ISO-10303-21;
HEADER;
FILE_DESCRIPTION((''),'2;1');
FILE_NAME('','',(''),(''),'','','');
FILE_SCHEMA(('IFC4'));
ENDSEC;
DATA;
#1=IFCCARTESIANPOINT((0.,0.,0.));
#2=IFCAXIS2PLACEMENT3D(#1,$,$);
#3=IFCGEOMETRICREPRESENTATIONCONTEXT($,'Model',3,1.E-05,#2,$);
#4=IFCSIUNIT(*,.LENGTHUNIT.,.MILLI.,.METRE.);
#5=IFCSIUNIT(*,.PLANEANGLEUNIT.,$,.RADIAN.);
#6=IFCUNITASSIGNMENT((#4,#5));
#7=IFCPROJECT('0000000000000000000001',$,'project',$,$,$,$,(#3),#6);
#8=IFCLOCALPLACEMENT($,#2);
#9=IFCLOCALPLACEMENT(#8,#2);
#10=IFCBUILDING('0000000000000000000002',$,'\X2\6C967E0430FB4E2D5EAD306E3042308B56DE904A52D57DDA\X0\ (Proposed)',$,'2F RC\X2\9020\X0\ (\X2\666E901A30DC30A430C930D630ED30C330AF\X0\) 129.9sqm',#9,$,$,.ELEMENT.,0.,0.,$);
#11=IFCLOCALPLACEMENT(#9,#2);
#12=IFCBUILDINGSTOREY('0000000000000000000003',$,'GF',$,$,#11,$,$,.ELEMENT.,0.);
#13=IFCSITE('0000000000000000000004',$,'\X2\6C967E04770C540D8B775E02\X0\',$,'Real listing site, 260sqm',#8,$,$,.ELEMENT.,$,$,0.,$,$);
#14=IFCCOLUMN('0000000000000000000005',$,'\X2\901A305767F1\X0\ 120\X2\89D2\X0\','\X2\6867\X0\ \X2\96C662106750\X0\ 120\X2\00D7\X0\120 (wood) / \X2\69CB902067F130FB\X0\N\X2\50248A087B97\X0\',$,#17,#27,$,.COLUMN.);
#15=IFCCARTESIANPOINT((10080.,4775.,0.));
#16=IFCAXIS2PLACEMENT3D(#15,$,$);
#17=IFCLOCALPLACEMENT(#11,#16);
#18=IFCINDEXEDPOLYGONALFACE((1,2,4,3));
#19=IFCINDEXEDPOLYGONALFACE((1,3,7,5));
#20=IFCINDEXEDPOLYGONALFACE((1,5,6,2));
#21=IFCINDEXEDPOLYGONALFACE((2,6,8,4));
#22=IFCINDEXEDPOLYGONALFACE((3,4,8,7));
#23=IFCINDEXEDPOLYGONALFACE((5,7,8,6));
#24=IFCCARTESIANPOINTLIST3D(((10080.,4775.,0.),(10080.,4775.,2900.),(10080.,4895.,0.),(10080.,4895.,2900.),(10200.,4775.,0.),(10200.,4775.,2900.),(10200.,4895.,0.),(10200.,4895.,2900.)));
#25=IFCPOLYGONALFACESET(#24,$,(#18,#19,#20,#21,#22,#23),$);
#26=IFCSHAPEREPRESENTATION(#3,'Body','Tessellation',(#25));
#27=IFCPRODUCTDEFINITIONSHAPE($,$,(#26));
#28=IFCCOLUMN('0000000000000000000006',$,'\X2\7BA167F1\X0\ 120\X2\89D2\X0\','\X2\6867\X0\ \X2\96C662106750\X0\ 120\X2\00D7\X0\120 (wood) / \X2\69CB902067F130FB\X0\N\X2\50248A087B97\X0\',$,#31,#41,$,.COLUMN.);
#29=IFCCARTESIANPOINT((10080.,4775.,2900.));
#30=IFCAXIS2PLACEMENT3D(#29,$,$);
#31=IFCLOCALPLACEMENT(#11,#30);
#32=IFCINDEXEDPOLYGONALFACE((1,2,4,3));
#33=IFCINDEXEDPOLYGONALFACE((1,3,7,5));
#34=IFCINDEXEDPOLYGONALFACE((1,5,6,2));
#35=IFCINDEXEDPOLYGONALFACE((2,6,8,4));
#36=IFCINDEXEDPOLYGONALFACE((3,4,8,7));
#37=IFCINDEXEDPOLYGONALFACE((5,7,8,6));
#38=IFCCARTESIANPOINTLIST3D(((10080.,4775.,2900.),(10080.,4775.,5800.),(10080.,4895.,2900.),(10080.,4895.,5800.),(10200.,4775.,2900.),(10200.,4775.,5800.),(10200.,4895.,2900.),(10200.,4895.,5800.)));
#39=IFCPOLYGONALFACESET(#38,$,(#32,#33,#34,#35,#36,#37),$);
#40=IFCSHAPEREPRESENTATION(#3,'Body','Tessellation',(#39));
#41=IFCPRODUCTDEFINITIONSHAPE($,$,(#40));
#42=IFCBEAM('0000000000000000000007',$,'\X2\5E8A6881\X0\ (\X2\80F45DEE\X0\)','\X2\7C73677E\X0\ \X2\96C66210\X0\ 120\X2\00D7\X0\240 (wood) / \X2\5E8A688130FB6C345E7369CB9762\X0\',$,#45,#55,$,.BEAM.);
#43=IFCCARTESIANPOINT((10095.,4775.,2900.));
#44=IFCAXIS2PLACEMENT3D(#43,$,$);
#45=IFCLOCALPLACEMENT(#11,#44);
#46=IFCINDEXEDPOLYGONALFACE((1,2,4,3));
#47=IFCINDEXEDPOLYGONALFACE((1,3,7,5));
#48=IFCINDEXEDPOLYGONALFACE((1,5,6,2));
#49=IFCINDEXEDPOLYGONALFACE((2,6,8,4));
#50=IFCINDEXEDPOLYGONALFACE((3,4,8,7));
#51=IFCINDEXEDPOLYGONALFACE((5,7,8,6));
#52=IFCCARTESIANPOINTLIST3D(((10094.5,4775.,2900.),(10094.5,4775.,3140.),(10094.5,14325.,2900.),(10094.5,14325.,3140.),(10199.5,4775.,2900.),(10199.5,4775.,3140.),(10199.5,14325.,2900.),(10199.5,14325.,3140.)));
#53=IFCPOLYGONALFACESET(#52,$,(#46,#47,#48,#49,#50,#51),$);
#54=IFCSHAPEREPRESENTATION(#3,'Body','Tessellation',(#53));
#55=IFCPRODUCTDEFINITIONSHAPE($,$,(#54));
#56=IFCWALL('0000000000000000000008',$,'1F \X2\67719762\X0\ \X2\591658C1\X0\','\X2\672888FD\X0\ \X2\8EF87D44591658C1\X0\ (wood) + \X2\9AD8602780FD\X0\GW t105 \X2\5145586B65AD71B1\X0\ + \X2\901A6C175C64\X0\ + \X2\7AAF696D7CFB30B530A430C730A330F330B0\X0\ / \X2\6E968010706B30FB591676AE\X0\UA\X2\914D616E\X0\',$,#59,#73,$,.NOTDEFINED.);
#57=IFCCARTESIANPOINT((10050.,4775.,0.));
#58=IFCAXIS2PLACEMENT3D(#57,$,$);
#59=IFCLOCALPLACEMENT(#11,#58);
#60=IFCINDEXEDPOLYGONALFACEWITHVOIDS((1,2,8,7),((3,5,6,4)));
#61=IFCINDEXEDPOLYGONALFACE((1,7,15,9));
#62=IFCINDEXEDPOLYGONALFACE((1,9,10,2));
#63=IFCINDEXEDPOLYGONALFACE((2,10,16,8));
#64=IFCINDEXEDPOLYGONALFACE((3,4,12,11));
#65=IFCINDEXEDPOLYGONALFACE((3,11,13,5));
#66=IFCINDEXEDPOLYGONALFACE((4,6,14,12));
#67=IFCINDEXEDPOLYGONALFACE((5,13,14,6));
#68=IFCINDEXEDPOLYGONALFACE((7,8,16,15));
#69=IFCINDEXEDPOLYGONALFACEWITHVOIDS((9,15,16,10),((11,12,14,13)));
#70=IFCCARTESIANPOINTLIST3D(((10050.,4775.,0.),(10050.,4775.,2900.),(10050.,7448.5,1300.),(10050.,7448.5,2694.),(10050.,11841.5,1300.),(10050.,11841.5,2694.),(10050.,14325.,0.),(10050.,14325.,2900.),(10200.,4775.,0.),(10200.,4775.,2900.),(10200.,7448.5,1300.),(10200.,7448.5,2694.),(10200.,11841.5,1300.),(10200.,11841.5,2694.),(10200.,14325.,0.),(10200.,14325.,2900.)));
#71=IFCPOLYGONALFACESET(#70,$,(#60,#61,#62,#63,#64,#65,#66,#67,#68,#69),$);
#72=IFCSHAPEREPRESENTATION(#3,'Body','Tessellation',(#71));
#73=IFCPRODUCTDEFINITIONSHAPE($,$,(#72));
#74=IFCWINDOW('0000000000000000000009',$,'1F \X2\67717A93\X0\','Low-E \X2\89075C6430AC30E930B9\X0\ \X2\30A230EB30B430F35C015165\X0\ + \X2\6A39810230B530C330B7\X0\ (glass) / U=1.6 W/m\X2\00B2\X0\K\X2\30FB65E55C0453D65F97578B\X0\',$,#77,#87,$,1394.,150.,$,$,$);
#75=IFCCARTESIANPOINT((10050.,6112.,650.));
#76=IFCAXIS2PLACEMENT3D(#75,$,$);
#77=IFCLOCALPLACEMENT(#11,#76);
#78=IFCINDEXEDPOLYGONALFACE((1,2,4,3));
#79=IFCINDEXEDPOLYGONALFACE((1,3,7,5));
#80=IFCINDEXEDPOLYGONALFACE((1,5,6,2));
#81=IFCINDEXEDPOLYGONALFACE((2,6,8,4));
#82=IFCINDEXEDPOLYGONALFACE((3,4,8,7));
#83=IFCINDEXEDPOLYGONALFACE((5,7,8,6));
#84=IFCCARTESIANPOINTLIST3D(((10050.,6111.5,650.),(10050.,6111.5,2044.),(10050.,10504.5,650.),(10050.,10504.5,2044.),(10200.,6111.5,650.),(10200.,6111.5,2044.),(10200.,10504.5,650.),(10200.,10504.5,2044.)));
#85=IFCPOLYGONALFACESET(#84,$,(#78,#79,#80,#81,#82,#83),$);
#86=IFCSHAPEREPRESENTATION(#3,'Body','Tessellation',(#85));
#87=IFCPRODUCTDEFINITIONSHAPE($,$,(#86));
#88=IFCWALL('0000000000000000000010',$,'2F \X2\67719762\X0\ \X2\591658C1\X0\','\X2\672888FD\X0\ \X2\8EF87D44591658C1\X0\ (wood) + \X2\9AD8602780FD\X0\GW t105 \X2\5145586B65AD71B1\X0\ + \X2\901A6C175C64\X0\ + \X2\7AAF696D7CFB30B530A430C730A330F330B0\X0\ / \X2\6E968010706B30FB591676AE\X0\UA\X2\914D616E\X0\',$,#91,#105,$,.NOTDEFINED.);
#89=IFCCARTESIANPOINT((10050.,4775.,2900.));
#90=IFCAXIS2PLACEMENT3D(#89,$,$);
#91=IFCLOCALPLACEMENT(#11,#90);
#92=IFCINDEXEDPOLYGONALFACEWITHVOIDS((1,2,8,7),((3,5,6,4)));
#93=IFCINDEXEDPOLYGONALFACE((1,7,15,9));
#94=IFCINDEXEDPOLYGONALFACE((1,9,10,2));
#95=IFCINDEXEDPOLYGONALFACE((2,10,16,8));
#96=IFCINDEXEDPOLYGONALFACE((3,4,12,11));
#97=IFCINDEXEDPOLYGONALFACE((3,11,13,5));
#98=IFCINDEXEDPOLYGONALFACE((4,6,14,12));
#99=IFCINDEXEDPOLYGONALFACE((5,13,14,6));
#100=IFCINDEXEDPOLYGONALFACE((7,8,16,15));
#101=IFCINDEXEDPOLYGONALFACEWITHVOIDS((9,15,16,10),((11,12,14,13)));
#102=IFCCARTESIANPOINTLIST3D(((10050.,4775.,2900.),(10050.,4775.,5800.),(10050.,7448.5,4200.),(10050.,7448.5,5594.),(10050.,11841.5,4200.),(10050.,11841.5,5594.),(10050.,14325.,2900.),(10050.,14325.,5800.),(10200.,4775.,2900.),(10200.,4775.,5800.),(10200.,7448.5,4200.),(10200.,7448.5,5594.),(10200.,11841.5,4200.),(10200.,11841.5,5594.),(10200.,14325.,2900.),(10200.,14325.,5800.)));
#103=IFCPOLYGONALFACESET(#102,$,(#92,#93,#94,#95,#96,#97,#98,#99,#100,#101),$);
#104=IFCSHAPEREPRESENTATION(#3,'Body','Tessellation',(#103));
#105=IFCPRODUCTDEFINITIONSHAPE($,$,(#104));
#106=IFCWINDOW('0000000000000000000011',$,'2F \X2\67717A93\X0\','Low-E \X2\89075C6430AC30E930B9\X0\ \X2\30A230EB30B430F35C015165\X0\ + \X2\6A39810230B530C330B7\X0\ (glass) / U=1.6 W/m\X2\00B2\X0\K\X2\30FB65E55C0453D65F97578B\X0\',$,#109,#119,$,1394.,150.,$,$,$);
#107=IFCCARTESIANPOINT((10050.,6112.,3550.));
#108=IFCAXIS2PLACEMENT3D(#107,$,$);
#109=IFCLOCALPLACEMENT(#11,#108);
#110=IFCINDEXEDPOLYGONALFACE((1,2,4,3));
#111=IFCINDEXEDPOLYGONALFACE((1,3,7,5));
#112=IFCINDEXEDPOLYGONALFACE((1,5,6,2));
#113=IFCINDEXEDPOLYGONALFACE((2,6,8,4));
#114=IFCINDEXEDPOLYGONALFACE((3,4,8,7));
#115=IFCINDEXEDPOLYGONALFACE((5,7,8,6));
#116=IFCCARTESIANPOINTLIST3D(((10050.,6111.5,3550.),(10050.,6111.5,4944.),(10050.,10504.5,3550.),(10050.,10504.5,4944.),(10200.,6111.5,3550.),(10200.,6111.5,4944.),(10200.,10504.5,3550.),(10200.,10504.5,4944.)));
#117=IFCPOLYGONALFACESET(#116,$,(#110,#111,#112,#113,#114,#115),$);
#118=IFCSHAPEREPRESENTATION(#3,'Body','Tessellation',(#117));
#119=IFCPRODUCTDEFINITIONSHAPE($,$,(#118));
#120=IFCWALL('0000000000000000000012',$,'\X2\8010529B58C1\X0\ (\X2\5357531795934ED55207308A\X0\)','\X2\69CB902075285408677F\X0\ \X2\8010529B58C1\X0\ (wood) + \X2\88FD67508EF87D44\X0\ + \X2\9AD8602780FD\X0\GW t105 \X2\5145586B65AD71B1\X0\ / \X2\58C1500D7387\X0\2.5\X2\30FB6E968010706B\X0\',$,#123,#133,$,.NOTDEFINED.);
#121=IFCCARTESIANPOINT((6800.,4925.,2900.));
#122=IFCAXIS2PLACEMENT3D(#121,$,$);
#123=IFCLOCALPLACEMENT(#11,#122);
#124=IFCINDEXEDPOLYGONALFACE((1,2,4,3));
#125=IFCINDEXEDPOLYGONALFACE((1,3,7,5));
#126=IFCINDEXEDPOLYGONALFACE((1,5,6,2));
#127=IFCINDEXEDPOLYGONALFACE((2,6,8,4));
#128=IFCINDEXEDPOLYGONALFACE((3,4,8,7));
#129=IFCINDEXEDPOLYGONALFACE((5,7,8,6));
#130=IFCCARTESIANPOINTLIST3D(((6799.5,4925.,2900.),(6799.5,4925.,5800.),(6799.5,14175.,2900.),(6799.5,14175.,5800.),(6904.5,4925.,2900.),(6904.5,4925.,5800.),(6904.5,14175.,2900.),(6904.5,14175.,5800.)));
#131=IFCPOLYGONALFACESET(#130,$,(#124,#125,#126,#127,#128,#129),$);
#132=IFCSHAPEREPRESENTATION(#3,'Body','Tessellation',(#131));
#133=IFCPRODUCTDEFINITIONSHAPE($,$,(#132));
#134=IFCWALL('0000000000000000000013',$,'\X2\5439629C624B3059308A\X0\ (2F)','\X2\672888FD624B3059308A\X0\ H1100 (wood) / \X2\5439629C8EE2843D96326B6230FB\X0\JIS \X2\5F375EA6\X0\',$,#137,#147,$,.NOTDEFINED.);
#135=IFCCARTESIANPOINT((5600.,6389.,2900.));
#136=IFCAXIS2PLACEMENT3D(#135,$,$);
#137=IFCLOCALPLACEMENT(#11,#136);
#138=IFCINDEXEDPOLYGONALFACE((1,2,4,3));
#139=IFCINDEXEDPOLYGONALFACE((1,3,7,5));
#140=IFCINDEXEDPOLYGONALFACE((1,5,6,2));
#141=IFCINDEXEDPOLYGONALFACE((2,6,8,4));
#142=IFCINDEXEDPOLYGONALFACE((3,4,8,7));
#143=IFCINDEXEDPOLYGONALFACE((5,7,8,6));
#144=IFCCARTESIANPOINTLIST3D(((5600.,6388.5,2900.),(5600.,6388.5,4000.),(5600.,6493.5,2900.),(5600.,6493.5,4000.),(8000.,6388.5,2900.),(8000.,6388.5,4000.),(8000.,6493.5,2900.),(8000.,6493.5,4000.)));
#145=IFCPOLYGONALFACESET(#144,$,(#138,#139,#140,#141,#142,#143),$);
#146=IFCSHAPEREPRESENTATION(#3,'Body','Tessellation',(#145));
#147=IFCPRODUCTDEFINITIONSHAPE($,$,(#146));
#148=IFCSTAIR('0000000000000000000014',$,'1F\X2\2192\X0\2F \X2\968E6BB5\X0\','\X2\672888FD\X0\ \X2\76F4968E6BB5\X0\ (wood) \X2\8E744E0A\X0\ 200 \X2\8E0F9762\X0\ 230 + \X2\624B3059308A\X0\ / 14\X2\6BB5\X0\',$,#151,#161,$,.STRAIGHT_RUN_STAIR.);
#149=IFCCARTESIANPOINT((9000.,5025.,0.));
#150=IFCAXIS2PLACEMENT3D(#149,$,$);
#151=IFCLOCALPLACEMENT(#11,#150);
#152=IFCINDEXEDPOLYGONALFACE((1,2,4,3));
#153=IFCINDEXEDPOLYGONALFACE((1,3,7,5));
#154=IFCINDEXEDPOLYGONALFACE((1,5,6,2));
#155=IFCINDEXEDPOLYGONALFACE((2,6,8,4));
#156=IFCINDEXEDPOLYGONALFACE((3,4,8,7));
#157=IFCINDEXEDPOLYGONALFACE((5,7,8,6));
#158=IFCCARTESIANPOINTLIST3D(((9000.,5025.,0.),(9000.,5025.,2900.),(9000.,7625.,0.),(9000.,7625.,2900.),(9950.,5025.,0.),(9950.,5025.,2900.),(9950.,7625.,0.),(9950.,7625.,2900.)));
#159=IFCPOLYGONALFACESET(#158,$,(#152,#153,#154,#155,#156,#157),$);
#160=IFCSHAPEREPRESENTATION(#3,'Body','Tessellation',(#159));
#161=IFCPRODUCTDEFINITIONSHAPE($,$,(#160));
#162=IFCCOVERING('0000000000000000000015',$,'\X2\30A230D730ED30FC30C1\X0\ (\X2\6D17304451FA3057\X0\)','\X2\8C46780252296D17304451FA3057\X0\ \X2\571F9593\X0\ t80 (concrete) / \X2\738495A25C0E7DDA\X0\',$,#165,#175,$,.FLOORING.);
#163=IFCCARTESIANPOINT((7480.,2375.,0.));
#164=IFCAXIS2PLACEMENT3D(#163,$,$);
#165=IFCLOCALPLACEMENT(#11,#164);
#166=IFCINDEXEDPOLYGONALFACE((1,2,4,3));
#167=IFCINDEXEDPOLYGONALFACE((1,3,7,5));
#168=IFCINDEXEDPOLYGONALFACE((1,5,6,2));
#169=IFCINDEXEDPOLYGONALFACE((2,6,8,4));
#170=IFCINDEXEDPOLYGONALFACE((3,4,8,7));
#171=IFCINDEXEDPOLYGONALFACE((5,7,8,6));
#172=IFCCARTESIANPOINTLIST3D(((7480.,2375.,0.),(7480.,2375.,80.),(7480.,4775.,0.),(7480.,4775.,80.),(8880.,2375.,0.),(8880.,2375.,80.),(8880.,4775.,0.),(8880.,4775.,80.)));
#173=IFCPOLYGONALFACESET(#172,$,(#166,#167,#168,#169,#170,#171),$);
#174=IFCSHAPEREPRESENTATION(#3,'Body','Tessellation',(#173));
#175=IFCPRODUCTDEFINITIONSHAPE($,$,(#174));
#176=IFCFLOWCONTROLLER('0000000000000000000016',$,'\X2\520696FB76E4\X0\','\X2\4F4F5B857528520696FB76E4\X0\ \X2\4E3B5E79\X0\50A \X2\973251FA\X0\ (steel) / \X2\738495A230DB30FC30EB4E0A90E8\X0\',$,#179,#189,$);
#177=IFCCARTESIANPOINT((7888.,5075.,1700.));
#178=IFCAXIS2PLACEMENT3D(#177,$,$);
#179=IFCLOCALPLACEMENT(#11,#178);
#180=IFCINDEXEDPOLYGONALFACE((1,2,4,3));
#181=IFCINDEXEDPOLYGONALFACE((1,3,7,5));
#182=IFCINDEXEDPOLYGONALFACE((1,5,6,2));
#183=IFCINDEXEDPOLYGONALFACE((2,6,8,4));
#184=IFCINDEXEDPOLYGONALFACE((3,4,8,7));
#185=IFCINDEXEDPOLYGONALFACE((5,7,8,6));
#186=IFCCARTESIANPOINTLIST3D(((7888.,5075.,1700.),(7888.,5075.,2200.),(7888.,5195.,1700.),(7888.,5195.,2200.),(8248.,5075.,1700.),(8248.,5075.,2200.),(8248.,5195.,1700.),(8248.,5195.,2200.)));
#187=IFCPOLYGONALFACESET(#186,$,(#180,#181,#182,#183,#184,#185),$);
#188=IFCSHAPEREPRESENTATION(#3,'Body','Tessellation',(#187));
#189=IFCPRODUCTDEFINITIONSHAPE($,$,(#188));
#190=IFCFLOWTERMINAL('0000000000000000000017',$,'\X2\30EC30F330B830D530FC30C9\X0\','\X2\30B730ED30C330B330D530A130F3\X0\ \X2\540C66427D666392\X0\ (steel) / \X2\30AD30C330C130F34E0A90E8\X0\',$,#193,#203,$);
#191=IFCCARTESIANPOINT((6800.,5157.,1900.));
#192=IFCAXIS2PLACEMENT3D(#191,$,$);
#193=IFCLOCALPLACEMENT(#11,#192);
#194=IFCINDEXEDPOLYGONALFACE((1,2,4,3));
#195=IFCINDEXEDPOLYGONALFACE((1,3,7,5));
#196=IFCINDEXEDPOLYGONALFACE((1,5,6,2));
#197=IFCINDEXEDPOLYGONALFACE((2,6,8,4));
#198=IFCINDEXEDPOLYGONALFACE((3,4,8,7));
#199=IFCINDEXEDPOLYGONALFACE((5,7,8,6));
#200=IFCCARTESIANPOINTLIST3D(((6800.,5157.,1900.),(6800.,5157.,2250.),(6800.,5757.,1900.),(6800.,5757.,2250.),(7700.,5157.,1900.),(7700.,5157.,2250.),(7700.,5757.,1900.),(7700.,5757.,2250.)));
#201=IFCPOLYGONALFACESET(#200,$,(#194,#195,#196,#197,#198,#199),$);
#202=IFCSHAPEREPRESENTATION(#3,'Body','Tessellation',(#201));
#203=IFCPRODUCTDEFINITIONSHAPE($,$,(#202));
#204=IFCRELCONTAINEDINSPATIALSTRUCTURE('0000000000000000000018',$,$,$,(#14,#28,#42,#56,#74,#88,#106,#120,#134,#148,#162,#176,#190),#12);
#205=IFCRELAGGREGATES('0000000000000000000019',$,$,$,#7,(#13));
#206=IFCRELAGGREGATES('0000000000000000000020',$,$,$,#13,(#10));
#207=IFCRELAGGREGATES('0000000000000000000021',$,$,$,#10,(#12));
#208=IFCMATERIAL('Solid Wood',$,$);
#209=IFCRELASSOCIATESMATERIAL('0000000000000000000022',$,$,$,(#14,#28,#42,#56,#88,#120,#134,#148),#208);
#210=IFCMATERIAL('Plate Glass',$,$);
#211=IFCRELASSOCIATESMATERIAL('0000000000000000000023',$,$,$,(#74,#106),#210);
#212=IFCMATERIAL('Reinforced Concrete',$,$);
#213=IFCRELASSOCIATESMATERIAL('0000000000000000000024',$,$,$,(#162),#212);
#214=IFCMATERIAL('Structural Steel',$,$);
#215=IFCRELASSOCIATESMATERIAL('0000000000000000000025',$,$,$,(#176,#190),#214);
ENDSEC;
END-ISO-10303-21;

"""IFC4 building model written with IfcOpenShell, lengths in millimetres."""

from ifc_helpers import new_model, si_unit, frame, frame_2d, origin, place, context, project, spatial, rectangle, extrude, material, element, fill, save


model = new_model("IFC4")

# Units and contexts
model_context = context("Model", 3, precision=1e-05, world=origin())
ifc_project = project(units=[si_unit("LENGTHUNIT", "METRE", prefix="MILLI"), si_unit("PLANEANGLEUNIT", "RADIAN")], contexts=[model_context])

# Site, building, storey
site_placement = place(None, origin())
site = spatial("IfcSite", under=ifc_project, at=site_placement, Name="沖縄県名護市", ObjectType="Real listing site, 260sqm", CompositionType="ELEMENT", RefElevation=0.0)
building_placement = place(site_placement, origin())
building = spatial("IfcBuilding", under=site, at=building_placement, Name="沖縄・中庭のある回遊動線 (Proposed)", ObjectType="2F RC造 (普通ボイドブロック) 129.9sqm", CompositionType="ELEMENT", ElevationOfRefHeight=0.0, ElevationOfTerrain=0.0)
storey_placement = place(building_placement, origin())
storey = spatial("IfcBuildingStorey", under=building, at=storey_placement, Name="GF", CompositionType="ELEMENT", Elevation=0.0)

# Columns
ifc_material_1 = material(Name="Solid Wood")
column_1_placement = place(storey_placement, frame((10080.0, 4775.0, 0.0)))
element("IfcColumn", 1, at=column_1_placement, inside=storey, material=ifc_material_1, Name="通し柱 120角", Description="桧 集成材 120×120 (wood) / 構造柱・N値計算", PredefinedType="COLUMN", context=model_context, shape_type="SweptSolid", body=[
    extrude(rectangle(XDim=120.0, YDim=120.0, at=frame_2d((60.0, 60.0))), frame((10080.0, 4775.0, 0.0)), (0.0, 0.0, 1.0), 2900.0),
])
column_2_placement = place(storey_placement, frame((10080.0, 4775.0, 2900.0)))
element("IfcColumn", 2, at=column_2_placement, inside=storey, material=ifc_material_1, Name="管柱 120角", Description="桧 集成材 120×120 (wood) / 構造柱・N値計算", PredefinedType="COLUMN", context=model_context, shape_type="SweptSolid", body=[
    extrude(rectangle(XDim=120.0, YDim=120.0, at=frame_2d((60.0, 60.0))), frame((10080.0, 4775.0, 2900.0)), (0.0, 0.0, 1.0), 2900.0),
])

# Beam
beam_1_placement = place(storey_placement, frame((10095.0, 4775.0, 2900.0)))
element("IfcBeam", 3, at=beam_1_placement, inside=storey, material=ifc_material_1, Name="床梁 (胴差)", Description="米松 集成 120×240 (wood) / 床梁・水平構面", PredefinedType="BEAM", context=model_context, shape_type="SweptSolid", body=[
    extrude(rectangle(XDim=105.0, YDim=9550.0, at=frame_2d((52.0, 4775.0))), frame((10095.0, 4775.0, 2900.0)), (0.0, 0.0, 1.0), 240.0),
])

# Wall, opening, window
wall_1_placement = place(storey_placement, frame((10050.0, 4775.0, 0.0)))
wall_1 = element("IfcWall", 4, at=wall_1_placement, inside=storey, material=ifc_material_1, Name="1F 東面 外壁", Description="木製 軸組外壁 (wood) + 高性能GW t105 充填断熱 + 通気層 + 窯業系サイディング / 準耐火・外皮UA配慮", PredefinedType="NOTDEFINED", context=model_context, shape_type="SweptSolid", body=[
    extrude(rectangle(XDim=150.0, YDim=9550.0, at=frame_2d((75.0, 4775.0))), frame((10050.0, 4775.0, 0.0)), (0.0, 0.0, 1.0), 2900.0),
])
opening_1_placement = place(storey_placement, frame((10050.0, 6112.0, 650.0)))
opening_1 = element("IfcOpeningElement", 5, at=opening_1_placement, cuts=wall_1, PredefinedType="NOTDEFINED", context=model_context, shape_type="SweptSolid", body=[
    extrude(rectangle(XDim=150.0, YDim=4393.0, at=frame_2d((75.0, 2196.0))), frame((10050.0, 6112.0, 650.0)), (0.0, 0.0, 1.0), 1394.0),
])
ifc_material_2 = material(Name="Plate Glass")
window_1_placement = place(storey_placement, frame((10050.0, 6112.0, 650.0)))
window_1 = element("IfcWindow", 6, at=window_1_placement, inside=storey, material=ifc_material_2, Name="1F 東窓", Description="Low-E 複層ガラス アルゴン封入 + 樹脂サッシ (glass) / U=1.6 W/m²K・日射取得型", OverallHeight=1394.0, OverallWidth=150.0, context=model_context, shape_type="SweptSolid", body=[
    extrude(rectangle(XDim=150.0, YDim=4393.0, at=frame_2d((75.0, 2196.0))), frame((10050.0, 6112.0, 650.0)), (0.0, 0.0, 1.0), 1394.0),
])
fill(opening_1, window_1)

# Wall, opening, window
wall_2_placement = place(storey_placement, frame((10050.0, 4775.0, 2900.0)))
wall_2 = element("IfcWall", 7, at=wall_2_placement, inside=storey, material=ifc_material_1, Name="2F 東面 外壁", Description="木製 軸組外壁 (wood) + 高性能GW t105 充填断熱 + 通気層 + 窯業系サイディング / 準耐火・外皮UA配慮", PredefinedType="NOTDEFINED", context=model_context, shape_type="SweptSolid", body=[
    extrude(rectangle(XDim=150.0, YDim=9550.0, at=frame_2d((75.0, 4775.0))), frame((10050.0, 4775.0, 2900.0)), (0.0, 0.0, 1.0), 2900.0),
])
opening_2_placement = place(storey_placement, frame((10050.0, 6112.0, 3550.0)))
opening_2 = element("IfcOpeningElement", 8, at=opening_2_placement, cuts=wall_2, PredefinedType="NOTDEFINED", context=model_context, shape_type="SweptSolid", body=[
    extrude(rectangle(XDim=150.0, YDim=4393.0, at=frame_2d((75.0, 2196.0))), frame((10050.0, 6112.0, 3550.0)), (0.0, 0.0, 1.0), 1394.0),
])
window_2_placement = place(storey_placement, frame((10050.0, 6112.0, 3550.0)))
window_2 = element("IfcWindow", 9, at=window_2_placement, inside=storey, material=ifc_material_2, Name="2F 東窓", Description="Low-E 複層ガラス アルゴン封入 + 樹脂サッシ (glass) / U=1.6 W/m²K・日射取得型", OverallHeight=1394.0, OverallWidth=150.0, context=model_context, shape_type="SweptSolid", body=[
    extrude(rectangle(XDim=150.0, YDim=4393.0, at=frame_2d((75.0, 2196.0))), frame((10050.0, 6112.0, 3550.0)), (0.0, 0.0, 1.0), 1394.0),
])
fill(opening_2, window_2)

# Walls
wall_3_placement = place(storey_placement, frame((6800.0, 4925.0, 2900.0)))
element("IfcWall", 10, at=wall_3_placement, inside=storey, material=ifc_material_1, Name="耐力壁 (南北間仕切り)", Description="構造用合板 耐力壁 (wood) + 製材軸組 + 高性能GW t105 充填断熱 / 壁倍率2.5・準耐火", PredefinedType="NOTDEFINED", context=model_context, shape_type="SweptSolid", body=[
    extrude(rectangle(XDim=105.0, YDim=9250.0, at=frame_2d((52.0, 4625.0))), frame((6800.0, 4925.0, 2900.0)), (0.0, 0.0, 1.0), 2900.0),
])
wall_4_placement = place(storey_placement, frame((5600.0, 6389.0, 2900.0)))
element("IfcWall", 11, at=wall_4_placement, inside=storey, material=ifc_material_1, Name="吹抜手すり (2F)", Description="木製手すり H1100 (wood) / 吹抜転落防止・JIS 強度", PredefinedType="NOTDEFINED", context=model_context, shape_type="SweptSolid", body=[
    extrude(rectangle(XDim=2400.0, YDim=105.0, at=frame_2d((1200.0, 52.0))), frame((5600.0, 6389.0, 2900.0)), (0.0, 0.0, 1.0), 1100.0),
])

# Stair
stair_placement = place(storey_placement, frame((9000.0, 5025.0, 0.0)))
element("IfcStair", 12, at=stair_placement, inside=storey, material=ifc_material_1, Name="1F→2F 階段", Description="木製 直階段 (wood) 蹴上 200 踏面 230 + 手すり / 14段", PredefinedType="STRAIGHT_RUN_STAIR", context=model_context, shape_type="SweptSolid", body=[
    extrude(rectangle(XDim=950.0, YDim=2600.0, at=frame_2d((475.0, 1300.0))), frame((9000.0, 5025.0, 0.0)), (0.0, 0.0, 1.0), 2900.0),
])

# Covering
ifc_material_3 = material(Name="Reinforced Concrete")
covering_placement = place(storey_placement, frame((7480.0, 2375.0, 0.0)))
element("IfcCovering", 13, at=covering_placement, inside=storey, material=ifc_material_3, Name="アプローチ (洗い出し)", Description="豆砂利洗い出し 土間 t80 (concrete) / 玄関導線", PredefinedType="FLOORING", context=model_context, shape_type="SweptSolid", body=[
    extrude(rectangle(XDim=1400.0, YDim=2400.0, at=frame_2d((700.0, 1200.0))), frame((7480.0, 2375.0, 0.0)), (0.0, 0.0, 1.0), 80.0),
])

# Flow controller
ifc_material_4 = material(Name="Structural Steel")
flow_controller_placement = place(storey_placement, frame((7888.0, 5075.0, 1700.0)))
element("IfcFlowController", 14, at=flow_controller_placement, inside=storey, material=ifc_material_4, Name="分電盤", Description="住宅用分電盤 主幹50A 露出 (steel) / 玄関ホール上部", context=model_context, shape_type="SweptSolid", body=[
    extrude(rectangle(XDim=360.0, YDim=120.0, at=frame_2d((180.0, 60.0))), frame((7888.0, 5075.0, 1700.0)), (0.0, 0.0, 1.0), 500.0),
])

# Flow terminal
flow_terminal_1_placement = place(storey_placement, frame((6800.0, 5157.0, 1900.0)))
element("IfcFlowTerminal", 15, at=flow_terminal_1_placement, inside=storey, material=ifc_material_4, Name="レンジフード", Description="シロッコファン 同時給排 (steel) / キッチン上部", context=model_context, shape_type="SweptSolid", body=[
    extrude(rectangle(XDim=900.0, YDim=600.0, at=frame_2d((450.0, 300.0))), frame((6800.0, 5157.0, 1900.0)), (0.0, 0.0, 1.0), 350.0),
])

save(model, "model.ifc")
